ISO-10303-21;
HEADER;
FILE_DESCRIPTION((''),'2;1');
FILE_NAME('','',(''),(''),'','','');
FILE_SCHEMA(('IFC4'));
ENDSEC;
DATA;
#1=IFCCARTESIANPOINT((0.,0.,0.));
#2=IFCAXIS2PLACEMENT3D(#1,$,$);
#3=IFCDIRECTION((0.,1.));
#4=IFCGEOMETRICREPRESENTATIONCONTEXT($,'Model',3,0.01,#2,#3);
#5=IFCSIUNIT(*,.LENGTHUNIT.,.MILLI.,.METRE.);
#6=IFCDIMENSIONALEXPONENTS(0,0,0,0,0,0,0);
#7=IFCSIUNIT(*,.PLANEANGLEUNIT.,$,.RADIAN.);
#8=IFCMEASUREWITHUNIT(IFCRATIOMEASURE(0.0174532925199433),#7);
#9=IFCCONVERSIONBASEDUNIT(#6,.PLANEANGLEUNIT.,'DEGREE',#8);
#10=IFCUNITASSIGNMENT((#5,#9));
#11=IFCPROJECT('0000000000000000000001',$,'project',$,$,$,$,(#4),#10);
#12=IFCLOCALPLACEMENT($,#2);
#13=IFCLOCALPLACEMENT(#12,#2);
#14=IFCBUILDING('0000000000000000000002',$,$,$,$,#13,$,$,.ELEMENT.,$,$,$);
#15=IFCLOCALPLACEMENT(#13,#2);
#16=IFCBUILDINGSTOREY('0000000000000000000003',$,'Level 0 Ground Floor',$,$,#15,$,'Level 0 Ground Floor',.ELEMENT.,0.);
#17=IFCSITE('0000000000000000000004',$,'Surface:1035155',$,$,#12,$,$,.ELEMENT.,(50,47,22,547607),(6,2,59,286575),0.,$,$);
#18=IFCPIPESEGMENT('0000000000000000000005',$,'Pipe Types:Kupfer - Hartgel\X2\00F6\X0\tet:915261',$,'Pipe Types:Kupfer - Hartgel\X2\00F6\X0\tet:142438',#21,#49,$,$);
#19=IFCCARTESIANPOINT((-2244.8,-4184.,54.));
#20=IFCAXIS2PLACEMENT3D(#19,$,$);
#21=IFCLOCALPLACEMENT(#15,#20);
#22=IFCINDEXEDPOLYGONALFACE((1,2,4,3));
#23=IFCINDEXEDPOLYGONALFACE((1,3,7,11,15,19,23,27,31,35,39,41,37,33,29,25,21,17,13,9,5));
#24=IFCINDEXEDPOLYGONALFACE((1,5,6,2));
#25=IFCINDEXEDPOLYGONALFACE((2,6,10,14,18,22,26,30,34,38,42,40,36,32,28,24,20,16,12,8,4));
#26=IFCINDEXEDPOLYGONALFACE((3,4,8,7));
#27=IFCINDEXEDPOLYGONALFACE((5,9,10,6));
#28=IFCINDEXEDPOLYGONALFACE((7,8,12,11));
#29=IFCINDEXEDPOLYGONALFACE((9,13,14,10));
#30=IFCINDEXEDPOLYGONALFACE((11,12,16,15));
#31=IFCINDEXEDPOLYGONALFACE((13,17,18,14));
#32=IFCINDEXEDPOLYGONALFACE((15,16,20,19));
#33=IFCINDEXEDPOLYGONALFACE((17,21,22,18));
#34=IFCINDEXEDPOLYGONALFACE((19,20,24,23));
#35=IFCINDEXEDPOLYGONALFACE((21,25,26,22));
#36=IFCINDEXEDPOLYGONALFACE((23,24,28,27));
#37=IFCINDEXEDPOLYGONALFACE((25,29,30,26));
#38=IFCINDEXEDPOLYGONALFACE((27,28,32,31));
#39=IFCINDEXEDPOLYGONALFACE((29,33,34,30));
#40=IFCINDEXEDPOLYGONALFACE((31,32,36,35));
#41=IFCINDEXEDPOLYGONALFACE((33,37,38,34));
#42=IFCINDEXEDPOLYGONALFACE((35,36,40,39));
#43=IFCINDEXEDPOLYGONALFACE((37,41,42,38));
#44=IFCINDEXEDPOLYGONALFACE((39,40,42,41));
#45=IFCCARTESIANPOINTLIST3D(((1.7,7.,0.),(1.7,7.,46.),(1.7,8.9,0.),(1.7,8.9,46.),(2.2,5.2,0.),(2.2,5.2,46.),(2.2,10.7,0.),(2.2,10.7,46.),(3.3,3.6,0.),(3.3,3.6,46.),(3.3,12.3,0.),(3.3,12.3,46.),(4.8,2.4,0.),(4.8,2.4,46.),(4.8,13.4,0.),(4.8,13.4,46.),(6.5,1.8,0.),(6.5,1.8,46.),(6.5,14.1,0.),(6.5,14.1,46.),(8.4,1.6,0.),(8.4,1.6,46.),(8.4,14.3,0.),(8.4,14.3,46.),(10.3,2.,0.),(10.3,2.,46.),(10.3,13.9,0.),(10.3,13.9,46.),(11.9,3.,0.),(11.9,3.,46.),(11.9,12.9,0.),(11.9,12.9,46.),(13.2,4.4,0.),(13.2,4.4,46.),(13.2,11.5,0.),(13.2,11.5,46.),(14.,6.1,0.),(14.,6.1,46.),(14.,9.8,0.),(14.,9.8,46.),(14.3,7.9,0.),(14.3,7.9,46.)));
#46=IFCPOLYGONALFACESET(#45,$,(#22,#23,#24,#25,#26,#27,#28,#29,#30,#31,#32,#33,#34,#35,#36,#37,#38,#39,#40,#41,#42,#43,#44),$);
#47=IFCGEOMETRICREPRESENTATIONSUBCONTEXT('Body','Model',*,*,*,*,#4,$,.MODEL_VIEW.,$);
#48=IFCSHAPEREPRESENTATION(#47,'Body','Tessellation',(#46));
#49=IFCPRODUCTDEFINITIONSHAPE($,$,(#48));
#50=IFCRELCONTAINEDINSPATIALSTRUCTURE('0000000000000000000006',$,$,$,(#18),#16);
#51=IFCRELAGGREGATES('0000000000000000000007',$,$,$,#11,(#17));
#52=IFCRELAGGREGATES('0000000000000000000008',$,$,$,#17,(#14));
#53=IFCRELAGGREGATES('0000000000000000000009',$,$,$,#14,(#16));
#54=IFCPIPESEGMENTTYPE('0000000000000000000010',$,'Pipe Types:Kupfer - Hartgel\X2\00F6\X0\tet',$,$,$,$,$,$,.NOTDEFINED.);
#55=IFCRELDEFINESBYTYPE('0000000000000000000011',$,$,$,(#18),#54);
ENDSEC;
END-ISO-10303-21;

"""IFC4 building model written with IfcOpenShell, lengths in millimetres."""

from ifc_helpers import new_model, entity, si_unit, converted_unit, direction, frame, origin, origin_2d_with_axis, place, context, subcontext, project, spatial, circle, extrude, type_object, element, save


model = new_model("IFC4")

# Units and contexts
model_context = context("Model", 3, precision=0.01, world=origin(), true_north=direction((0.0, 1.0)))
body_context = subcontext(model_context, "Body", "Model", "MODEL_VIEW")
ifc_project = project(units=[si_unit("LENGTHUNIT", "METRE", prefix="MILLI"), converted_unit("PLANEANGLEUNIT", "DEGREE", entity("IfcRatioMeasure", 0.0174532925199433), si_unit("PLANEANGLEUNIT", "RADIAN"), dimensions=[0, 0, 0, 0, 0, 0, 0])], contexts=[model_context])

# Site, building, storey
site_placement = place(None, origin())
site = spatial("IfcSite", under=ifc_project, at=site_placement, Name="Surface:1035155", CompositionType="ELEMENT", RefLatitude=(50, 47, 22, 547607), RefLongitude=(6, 2, 59, 286575), RefElevation=0.0)
building_placement = place(site_placement, origin())
building = spatial("IfcBuilding", under=site, at=building_placement, CompositionType="ELEMENT")
storey_placement = place(building_placement, origin())
storey = spatial("IfcBuildingStorey", under=building, at=storey_placement, Name="Level 0 Ground Floor", LongName="Level 0 Ground Floor", CompositionType="ELEMENT", Elevation=0.0)

# Pipe segment
pipe_segment_type = type_object("IfcPipeSegmentType", Name="Pipe Types:Kupfer - Hartgelötet", PredefinedType="NOTDEFINED")
pipe_segment_1_placement = place(storey_placement, frame((-2244.8, -4184.0, 54.0)))
element("IfcPipeSegment", 1, at=pipe_segment_1_placement, inside=storey, type_object=pipe_segment_type, Name="Pipe Types:Kupfer - Hartgelötet:915261", ObjectType="Pipe Types:Kupfer - Hartgelötet:142438", context=body_context, shape_type="SweptSolid", body=[
    extrude(circle(Radius=6.3, at=origin_2d_with_axis()), frame((7.9, 7.9, 0.0)), (0.0, 0.0, 1.0), 46.0),
])

save(model, "model.ifc")
